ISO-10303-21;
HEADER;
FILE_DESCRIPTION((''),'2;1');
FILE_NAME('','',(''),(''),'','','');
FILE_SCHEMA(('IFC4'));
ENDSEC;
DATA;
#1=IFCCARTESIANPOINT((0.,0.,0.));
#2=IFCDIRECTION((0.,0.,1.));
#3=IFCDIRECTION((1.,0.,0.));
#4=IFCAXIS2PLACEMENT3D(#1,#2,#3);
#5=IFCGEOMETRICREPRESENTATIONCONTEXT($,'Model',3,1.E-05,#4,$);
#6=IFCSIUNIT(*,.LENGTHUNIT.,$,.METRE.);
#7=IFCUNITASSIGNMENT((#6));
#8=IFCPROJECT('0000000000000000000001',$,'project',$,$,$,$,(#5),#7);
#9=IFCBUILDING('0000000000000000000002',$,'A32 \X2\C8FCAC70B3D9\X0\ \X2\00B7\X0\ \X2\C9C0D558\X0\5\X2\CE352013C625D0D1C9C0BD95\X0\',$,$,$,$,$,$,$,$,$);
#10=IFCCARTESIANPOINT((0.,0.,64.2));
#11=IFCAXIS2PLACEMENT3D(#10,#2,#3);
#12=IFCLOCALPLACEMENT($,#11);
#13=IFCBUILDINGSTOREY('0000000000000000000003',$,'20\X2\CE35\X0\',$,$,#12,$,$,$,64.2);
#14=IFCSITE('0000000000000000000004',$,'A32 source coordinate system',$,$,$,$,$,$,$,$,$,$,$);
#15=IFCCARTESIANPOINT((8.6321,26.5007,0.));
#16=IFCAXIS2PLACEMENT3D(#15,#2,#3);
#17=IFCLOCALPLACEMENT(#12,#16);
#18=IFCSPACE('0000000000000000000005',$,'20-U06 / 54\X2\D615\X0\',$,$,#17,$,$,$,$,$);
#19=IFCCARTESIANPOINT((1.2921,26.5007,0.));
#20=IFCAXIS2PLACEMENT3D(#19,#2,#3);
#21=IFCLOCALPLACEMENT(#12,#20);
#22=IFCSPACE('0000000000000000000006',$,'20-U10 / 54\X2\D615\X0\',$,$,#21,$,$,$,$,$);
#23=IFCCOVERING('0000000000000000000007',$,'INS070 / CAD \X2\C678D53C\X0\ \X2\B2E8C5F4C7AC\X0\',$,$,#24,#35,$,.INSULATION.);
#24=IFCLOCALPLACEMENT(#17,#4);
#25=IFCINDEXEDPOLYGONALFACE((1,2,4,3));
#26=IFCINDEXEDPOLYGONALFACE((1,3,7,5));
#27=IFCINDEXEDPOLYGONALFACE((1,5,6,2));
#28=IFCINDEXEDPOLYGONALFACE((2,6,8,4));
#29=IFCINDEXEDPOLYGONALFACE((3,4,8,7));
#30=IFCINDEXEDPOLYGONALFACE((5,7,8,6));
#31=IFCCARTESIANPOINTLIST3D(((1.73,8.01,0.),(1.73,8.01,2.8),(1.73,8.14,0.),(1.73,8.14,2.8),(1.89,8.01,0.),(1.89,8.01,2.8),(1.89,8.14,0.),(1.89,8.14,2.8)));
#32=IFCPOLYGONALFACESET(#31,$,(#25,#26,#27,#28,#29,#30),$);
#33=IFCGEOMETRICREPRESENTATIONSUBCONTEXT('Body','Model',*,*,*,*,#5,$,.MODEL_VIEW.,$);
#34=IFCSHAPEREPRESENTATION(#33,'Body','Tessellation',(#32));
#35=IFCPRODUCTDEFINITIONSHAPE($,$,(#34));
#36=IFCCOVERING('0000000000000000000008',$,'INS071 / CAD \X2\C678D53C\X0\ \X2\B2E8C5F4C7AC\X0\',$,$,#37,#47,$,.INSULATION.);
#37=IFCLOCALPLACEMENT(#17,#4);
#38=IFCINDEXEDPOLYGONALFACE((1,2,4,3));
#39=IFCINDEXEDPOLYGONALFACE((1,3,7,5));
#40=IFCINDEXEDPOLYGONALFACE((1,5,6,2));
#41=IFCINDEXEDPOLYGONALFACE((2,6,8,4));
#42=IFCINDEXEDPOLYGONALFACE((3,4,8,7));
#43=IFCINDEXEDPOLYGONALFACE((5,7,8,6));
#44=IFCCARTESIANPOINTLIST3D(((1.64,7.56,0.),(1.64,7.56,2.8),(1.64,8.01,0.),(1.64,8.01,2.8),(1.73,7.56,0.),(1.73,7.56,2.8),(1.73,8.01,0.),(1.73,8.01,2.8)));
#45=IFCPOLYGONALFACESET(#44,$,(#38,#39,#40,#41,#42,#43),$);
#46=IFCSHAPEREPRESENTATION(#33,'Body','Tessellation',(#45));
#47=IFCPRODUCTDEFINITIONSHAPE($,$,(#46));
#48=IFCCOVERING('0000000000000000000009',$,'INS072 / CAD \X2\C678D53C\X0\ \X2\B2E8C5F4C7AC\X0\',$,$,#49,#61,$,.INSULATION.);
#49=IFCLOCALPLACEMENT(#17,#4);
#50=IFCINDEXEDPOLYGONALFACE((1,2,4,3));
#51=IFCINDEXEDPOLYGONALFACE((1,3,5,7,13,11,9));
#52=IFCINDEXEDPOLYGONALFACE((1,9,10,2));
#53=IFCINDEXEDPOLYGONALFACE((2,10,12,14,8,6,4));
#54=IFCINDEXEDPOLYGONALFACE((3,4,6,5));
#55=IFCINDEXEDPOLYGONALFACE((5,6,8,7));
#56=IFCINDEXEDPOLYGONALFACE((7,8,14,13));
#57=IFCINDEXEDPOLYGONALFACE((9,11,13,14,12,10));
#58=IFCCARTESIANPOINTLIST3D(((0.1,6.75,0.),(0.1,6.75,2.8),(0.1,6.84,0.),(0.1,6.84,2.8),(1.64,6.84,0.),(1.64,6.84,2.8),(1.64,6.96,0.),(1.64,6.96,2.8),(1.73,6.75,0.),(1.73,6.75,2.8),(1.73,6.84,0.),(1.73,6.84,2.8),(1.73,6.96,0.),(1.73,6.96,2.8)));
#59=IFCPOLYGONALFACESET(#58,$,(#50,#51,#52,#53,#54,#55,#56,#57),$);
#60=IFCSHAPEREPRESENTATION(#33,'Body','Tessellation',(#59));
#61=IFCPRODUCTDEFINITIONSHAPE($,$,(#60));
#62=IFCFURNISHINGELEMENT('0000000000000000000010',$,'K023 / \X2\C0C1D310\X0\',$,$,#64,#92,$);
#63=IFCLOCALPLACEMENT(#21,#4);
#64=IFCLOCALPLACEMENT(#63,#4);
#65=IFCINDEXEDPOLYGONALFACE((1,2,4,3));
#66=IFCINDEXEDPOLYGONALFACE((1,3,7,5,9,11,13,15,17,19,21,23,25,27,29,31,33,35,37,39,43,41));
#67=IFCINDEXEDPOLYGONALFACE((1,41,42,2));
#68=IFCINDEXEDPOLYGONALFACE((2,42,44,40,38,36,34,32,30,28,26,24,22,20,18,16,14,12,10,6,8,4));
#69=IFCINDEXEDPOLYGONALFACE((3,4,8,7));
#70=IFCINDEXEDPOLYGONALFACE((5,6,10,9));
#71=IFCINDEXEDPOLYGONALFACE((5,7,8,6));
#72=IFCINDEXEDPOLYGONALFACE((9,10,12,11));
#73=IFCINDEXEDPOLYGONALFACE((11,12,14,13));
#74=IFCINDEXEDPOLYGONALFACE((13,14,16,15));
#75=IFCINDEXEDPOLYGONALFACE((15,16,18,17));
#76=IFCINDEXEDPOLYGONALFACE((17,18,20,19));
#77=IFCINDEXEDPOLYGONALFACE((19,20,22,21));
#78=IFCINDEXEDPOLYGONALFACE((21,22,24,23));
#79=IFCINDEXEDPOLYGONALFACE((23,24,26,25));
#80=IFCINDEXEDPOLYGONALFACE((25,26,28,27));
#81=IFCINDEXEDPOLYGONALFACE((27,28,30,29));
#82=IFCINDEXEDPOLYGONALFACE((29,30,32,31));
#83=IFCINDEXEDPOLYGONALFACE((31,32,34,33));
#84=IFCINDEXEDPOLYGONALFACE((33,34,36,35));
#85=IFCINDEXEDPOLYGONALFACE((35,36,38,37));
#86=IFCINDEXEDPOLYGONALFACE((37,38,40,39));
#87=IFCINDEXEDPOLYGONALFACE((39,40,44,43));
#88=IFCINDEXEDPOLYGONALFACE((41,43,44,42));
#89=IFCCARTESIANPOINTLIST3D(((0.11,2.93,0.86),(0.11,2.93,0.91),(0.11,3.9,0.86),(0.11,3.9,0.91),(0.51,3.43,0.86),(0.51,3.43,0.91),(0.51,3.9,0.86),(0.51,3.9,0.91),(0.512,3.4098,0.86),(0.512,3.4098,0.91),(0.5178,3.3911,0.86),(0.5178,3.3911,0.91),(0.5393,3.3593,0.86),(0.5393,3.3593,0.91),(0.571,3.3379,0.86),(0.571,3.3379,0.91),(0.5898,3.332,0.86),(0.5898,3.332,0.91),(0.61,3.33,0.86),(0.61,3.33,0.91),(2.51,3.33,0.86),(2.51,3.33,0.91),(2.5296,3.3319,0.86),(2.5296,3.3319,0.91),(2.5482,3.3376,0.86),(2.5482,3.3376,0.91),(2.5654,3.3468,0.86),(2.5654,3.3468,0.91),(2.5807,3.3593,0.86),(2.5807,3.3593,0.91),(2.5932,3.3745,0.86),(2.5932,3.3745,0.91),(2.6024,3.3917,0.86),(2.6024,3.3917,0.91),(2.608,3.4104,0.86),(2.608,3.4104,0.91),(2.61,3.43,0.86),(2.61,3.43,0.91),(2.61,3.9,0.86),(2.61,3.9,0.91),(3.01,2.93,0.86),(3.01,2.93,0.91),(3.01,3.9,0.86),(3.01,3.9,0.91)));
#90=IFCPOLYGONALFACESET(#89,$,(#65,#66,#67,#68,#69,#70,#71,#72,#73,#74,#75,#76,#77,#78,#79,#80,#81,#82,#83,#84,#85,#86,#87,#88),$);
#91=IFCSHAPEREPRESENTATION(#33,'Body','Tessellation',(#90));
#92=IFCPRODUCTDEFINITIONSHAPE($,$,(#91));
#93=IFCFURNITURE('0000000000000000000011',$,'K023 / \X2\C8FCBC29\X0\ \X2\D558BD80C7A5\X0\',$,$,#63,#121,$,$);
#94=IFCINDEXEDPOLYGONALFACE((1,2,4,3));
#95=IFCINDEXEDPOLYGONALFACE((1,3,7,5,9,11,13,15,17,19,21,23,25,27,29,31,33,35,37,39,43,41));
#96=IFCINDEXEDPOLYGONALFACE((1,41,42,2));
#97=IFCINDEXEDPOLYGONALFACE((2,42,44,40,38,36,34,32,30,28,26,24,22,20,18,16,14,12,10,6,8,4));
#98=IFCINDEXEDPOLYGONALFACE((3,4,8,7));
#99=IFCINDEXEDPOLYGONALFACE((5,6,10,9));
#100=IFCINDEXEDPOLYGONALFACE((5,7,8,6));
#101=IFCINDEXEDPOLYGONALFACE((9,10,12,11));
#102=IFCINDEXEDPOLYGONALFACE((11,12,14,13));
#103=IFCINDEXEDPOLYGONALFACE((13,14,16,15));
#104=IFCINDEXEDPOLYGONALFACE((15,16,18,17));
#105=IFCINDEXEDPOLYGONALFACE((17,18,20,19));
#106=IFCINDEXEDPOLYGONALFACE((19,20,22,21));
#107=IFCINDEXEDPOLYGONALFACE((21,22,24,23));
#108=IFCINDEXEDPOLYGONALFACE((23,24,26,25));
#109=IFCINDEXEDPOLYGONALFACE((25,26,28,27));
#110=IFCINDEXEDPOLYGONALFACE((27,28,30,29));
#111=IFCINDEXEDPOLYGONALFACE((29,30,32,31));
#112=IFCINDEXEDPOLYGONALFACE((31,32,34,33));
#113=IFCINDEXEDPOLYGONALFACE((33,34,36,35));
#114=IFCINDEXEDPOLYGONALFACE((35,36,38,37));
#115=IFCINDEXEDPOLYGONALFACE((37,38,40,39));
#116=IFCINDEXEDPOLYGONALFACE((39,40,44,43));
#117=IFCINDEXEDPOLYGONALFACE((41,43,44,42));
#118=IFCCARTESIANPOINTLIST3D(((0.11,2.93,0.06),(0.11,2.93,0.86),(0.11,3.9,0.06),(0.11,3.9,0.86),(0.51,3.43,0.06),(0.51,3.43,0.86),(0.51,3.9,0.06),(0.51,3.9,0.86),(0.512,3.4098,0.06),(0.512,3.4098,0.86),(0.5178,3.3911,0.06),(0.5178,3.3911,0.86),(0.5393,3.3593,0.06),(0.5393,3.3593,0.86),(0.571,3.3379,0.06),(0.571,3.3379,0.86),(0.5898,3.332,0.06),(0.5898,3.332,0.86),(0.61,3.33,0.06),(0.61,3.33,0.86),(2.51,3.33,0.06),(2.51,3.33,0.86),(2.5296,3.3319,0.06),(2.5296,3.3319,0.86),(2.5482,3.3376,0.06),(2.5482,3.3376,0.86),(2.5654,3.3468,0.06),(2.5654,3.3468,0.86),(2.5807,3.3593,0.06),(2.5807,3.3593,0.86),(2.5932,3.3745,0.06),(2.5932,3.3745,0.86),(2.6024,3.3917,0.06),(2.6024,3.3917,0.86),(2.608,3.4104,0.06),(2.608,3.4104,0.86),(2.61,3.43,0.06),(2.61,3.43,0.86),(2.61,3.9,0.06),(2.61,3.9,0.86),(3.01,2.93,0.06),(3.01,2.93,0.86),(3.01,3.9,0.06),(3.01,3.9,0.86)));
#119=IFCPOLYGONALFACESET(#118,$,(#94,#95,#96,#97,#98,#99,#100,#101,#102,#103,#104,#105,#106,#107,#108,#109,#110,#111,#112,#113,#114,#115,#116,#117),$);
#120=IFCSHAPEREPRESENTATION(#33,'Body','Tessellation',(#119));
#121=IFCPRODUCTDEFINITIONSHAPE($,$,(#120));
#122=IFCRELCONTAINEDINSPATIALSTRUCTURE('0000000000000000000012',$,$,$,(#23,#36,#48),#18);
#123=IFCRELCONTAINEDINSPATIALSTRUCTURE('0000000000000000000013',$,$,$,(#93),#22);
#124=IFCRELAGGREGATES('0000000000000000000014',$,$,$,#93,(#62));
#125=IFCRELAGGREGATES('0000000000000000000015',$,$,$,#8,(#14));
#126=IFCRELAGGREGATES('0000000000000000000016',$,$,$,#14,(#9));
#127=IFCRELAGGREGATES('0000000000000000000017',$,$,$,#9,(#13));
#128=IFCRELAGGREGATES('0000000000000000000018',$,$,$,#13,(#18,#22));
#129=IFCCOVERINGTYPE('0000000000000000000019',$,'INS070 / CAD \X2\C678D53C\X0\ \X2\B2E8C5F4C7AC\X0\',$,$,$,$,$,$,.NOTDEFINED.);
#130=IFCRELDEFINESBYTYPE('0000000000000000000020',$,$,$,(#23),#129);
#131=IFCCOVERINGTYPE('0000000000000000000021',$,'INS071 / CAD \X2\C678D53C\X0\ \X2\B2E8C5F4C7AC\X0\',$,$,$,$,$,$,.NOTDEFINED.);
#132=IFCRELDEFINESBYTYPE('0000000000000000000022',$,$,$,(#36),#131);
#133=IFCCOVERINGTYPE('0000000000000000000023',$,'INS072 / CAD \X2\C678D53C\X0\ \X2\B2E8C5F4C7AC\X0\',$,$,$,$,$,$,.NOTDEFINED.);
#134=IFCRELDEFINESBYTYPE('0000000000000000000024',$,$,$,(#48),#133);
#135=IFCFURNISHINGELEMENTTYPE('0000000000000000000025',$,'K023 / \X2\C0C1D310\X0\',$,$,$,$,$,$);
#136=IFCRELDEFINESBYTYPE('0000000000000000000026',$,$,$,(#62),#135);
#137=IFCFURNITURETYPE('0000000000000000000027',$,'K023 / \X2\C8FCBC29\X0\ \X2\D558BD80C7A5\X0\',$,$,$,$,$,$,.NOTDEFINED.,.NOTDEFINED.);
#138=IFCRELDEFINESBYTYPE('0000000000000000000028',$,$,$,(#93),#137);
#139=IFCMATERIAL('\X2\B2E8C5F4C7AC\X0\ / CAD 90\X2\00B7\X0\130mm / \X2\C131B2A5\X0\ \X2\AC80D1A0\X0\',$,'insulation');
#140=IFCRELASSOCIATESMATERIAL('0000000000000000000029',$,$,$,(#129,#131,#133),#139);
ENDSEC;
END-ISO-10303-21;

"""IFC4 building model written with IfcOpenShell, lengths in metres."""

from ifc_helpers import new_model, si_unit, frame, origin, origin_with_axes, place, context, subcontext, project, spatial, polyline, outline, extrude, source, transform, mapped, material, type_object, type_shapes, element, aggregate, save


model = new_model("IFC4")

# Units and contexts
model_context = context("Model", 3, precision=1e-05, world=origin_with_axes())
body_context = subcontext(model_context, "Body", "Model", "MODEL_VIEW")
ifc_project = project(units=[si_unit("LENGTHUNIT", "METRE")], contexts=[model_context])

# Site, building, storey, space
storey_placement = place(None, frame((0.0, 0.0, 64.2), z_axis=(0.0, 0.0, 1.0), x_axis=(1.0, 0.0, 0.0)))
space_1_placement = place(storey_placement, frame((8.6321, 26.5007, 0.0), z_axis=(0.0, 0.0, 1.0), x_axis=(1.0, 0.0, 0.0)))
site = spatial("IfcSite", under=ifc_project, Name="A32 source coordinate system")
building = spatial("IfcBuilding", under=site, Name="A32 주거동 · 지하5층–옥탑지붕")
storey = spatial("IfcBuildingStorey", under=building, at=storey_placement, Name="20층", Elevation=64.2)
space_1 = spatial("IfcSpace", under=storey, at=space_1_placement, Name="20-U06 / 54형")

# Coverings
ifc_material = material(Name="단열재 / CAD 90·130mm / 성능 검토", Category="insulation")
covering_type_1 = type_object("IfcCoveringType", Name="INS070 / CAD 외피 단열재", PredefinedType="NOTDEFINED", material=ifc_material)
shared_shape_1 = source(origin(), body_context, "Body", "SweptSolid", [
    extrude(outline(polyline([(1.73, 8.14), (1.89, 8.14), (1.89, 8.01), (1.73, 8.01), (1.73, 8.14)])), origin(), (0.0, 0.0, 1.0), 2.8),
])
type_shapes(covering_type_1, [shared_shape_1])
covering_1_placement = place(space_1_placement, origin_with_axes())
element("IfcCovering", 1, at=covering_1_placement, inside=space_1, type_object=covering_type_1, Name="INS070 / CAD 외피 단열재", PredefinedType="INSULATION", context=body_context, shape_type="MappedRepresentation", body=[
    mapped(shared_shape_1, transform((0.0, 0.0, 0.0), scale=1.0)),
])
covering_type_2 = type_object("IfcCoveringType", Name="INS071 / CAD 외피 단열재", PredefinedType="NOTDEFINED", material=ifc_material)
shared_shape_2 = source(origin(), body_context, "Body", "SweptSolid", [
    extrude(outline(polyline([(1.73, 7.56), (1.64, 7.56), (1.64, 8.01), (1.73, 8.01), (1.73, 7.56)])), origin(), (0.0, 0.0, 1.0), 2.8),
])
type_shapes(covering_type_2, [shared_shape_2])
covering_2_placement = place(space_1_placement, origin_with_axes())
element("IfcCovering", 2, at=covering_2_placement, inside=space_1, type_object=covering_type_2, Name="INS071 / CAD 외피 단열재", PredefinedType="INSULATION", context=body_context, shape_type="MappedRepresentation", body=[
    mapped(shared_shape_2, transform((0.0, 0.0, 0.0), scale=1.0)),
])
covering_type_3 = type_object("IfcCoveringType", Name="INS072 / CAD 외피 단열재", PredefinedType="NOTDEFINED", material=ifc_material)
shared_shape_3 = source(origin(), body_context, "Body", "SweptSolid", [
    extrude(outline(polyline([(1.64, 6.84), (1.64, 6.96), (1.73, 6.96), (1.73, 6.84), (1.73, 6.75), (0.1, 6.75), (0.1, 6.84), (1.64, 6.84)])), origin(), (0.0, 0.0, 1.0), 2.8),
])
type_shapes(covering_type_3, [shared_shape_3])
covering_3_placement = place(space_1_placement, origin_with_axes())
element("IfcCovering", 3, at=covering_3_placement, inside=space_1, type_object=covering_type_3, Name="INS072 / CAD 외피 단열재", PredefinedType="INSULATION", context=body_context, shape_type="MappedRepresentation", body=[
    mapped(shared_shape_3, transform((0.0, 0.0, 0.0), scale=1.0)),
])

# Shared definitions
space_2_placement = place(storey_placement, frame((1.2921, 26.5007, 0.0), z_axis=(0.0, 0.0, 1.0), x_axis=(1.0, 0.0, 0.0)))

# Furnishing element
furnishing_element_type_1 = type_object("IfcFurnishingElementType", Name="K023 / 상판")
shared_shape_4 = source(origin(), body_context, "Body", "SweptSolid", [
    extrude(outline(polyline([(0.51, 3.43), (0.512, 3.4098), (0.5178, 3.3911), (0.5393, 3.3593), (0.571, 3.3379), (0.5898, 3.332), (0.61, 3.33), (2.51, 3.33), (2.5296, 3.3319), (2.5482, 3.3376), (2.5654, 3.3468), (2.5807, 3.3593), (2.5932, 3.3745), (2.6024, 3.3917), (2.608, 3.4104), (2.61, 3.43), (2.61, 3.9), (3.01, 3.9), (3.01, 2.93), (0.11, 2.93), (0.11, 3.9), (0.51, 3.9), (0.51, 3.43)])), frame((0.0, 0.0, 0.86)), (0.0, 0.0, 1.0), 0.05),
])
type_shapes(furnishing_element_type_1, [shared_shape_4])
furniture_1_placement = place(space_2_placement, origin_with_axes())
furnishing_1_placement = place(furniture_1_placement, origin_with_axes())
furnishing_1 = element("IfcFurnishingElement", 4, at=furnishing_1_placement, type_object=furnishing_element_type_1, Name="K023 / 상판", context=body_context, shape_type="MappedRepresentation", body=[
    mapped(shared_shape_4, transform((0.0, 0.0, 0.0), scale=1.0)),
])

# Shared definitions
space_2 = spatial("IfcSpace", under=storey, at=space_2_placement, Name="20-U10 / 54형")

# Furniture
furniture_type_1 = type_object("IfcFurnitureType", Name="K023 / 주방 하부장", AssemblyPlace="NOTDEFINED", PredefinedType="NOTDEFINED")
shared_shape_5 = source(origin(), body_context, "Body", "SweptSolid", [
    extrude(outline(polyline([(0.51, 3.9), (0.51, 3.43), (0.512, 3.4098), (0.5178, 3.3911), (0.5393, 3.3593), (0.571, 3.3379), (0.5898, 3.332), (0.61, 3.33), (2.51, 3.33), (2.5296, 3.3319), (2.5482, 3.3376), (2.5654, 3.3468), (2.5807, 3.3593), (2.5932, 3.3745), (2.6024, 3.3917), (2.608, 3.4104), (2.61, 3.43), (2.61, 3.9), (3.01, 3.9), (3.01, 2.93), (0.11, 2.93), (0.11, 3.9), (0.51, 3.9)])), frame((0.0, 0.0, 0.06)), (0.0, 0.0, 1.0), 0.8),
])
type_shapes(furniture_type_1, [shared_shape_5])
furniture_1 = element("IfcFurniture", 5, at=furniture_1_placement, inside=space_2, type_object=furniture_type_1, Name="K023 / 주방 하부장", context=body_context, shape_type="MappedRepresentation", body=[
    mapped(shared_shape_5, transform((0.0, 0.0, 0.0), scale=1.0)),
])
aggregate(furniture_1, [furnishing_1])

save(model, "model.ifc")
